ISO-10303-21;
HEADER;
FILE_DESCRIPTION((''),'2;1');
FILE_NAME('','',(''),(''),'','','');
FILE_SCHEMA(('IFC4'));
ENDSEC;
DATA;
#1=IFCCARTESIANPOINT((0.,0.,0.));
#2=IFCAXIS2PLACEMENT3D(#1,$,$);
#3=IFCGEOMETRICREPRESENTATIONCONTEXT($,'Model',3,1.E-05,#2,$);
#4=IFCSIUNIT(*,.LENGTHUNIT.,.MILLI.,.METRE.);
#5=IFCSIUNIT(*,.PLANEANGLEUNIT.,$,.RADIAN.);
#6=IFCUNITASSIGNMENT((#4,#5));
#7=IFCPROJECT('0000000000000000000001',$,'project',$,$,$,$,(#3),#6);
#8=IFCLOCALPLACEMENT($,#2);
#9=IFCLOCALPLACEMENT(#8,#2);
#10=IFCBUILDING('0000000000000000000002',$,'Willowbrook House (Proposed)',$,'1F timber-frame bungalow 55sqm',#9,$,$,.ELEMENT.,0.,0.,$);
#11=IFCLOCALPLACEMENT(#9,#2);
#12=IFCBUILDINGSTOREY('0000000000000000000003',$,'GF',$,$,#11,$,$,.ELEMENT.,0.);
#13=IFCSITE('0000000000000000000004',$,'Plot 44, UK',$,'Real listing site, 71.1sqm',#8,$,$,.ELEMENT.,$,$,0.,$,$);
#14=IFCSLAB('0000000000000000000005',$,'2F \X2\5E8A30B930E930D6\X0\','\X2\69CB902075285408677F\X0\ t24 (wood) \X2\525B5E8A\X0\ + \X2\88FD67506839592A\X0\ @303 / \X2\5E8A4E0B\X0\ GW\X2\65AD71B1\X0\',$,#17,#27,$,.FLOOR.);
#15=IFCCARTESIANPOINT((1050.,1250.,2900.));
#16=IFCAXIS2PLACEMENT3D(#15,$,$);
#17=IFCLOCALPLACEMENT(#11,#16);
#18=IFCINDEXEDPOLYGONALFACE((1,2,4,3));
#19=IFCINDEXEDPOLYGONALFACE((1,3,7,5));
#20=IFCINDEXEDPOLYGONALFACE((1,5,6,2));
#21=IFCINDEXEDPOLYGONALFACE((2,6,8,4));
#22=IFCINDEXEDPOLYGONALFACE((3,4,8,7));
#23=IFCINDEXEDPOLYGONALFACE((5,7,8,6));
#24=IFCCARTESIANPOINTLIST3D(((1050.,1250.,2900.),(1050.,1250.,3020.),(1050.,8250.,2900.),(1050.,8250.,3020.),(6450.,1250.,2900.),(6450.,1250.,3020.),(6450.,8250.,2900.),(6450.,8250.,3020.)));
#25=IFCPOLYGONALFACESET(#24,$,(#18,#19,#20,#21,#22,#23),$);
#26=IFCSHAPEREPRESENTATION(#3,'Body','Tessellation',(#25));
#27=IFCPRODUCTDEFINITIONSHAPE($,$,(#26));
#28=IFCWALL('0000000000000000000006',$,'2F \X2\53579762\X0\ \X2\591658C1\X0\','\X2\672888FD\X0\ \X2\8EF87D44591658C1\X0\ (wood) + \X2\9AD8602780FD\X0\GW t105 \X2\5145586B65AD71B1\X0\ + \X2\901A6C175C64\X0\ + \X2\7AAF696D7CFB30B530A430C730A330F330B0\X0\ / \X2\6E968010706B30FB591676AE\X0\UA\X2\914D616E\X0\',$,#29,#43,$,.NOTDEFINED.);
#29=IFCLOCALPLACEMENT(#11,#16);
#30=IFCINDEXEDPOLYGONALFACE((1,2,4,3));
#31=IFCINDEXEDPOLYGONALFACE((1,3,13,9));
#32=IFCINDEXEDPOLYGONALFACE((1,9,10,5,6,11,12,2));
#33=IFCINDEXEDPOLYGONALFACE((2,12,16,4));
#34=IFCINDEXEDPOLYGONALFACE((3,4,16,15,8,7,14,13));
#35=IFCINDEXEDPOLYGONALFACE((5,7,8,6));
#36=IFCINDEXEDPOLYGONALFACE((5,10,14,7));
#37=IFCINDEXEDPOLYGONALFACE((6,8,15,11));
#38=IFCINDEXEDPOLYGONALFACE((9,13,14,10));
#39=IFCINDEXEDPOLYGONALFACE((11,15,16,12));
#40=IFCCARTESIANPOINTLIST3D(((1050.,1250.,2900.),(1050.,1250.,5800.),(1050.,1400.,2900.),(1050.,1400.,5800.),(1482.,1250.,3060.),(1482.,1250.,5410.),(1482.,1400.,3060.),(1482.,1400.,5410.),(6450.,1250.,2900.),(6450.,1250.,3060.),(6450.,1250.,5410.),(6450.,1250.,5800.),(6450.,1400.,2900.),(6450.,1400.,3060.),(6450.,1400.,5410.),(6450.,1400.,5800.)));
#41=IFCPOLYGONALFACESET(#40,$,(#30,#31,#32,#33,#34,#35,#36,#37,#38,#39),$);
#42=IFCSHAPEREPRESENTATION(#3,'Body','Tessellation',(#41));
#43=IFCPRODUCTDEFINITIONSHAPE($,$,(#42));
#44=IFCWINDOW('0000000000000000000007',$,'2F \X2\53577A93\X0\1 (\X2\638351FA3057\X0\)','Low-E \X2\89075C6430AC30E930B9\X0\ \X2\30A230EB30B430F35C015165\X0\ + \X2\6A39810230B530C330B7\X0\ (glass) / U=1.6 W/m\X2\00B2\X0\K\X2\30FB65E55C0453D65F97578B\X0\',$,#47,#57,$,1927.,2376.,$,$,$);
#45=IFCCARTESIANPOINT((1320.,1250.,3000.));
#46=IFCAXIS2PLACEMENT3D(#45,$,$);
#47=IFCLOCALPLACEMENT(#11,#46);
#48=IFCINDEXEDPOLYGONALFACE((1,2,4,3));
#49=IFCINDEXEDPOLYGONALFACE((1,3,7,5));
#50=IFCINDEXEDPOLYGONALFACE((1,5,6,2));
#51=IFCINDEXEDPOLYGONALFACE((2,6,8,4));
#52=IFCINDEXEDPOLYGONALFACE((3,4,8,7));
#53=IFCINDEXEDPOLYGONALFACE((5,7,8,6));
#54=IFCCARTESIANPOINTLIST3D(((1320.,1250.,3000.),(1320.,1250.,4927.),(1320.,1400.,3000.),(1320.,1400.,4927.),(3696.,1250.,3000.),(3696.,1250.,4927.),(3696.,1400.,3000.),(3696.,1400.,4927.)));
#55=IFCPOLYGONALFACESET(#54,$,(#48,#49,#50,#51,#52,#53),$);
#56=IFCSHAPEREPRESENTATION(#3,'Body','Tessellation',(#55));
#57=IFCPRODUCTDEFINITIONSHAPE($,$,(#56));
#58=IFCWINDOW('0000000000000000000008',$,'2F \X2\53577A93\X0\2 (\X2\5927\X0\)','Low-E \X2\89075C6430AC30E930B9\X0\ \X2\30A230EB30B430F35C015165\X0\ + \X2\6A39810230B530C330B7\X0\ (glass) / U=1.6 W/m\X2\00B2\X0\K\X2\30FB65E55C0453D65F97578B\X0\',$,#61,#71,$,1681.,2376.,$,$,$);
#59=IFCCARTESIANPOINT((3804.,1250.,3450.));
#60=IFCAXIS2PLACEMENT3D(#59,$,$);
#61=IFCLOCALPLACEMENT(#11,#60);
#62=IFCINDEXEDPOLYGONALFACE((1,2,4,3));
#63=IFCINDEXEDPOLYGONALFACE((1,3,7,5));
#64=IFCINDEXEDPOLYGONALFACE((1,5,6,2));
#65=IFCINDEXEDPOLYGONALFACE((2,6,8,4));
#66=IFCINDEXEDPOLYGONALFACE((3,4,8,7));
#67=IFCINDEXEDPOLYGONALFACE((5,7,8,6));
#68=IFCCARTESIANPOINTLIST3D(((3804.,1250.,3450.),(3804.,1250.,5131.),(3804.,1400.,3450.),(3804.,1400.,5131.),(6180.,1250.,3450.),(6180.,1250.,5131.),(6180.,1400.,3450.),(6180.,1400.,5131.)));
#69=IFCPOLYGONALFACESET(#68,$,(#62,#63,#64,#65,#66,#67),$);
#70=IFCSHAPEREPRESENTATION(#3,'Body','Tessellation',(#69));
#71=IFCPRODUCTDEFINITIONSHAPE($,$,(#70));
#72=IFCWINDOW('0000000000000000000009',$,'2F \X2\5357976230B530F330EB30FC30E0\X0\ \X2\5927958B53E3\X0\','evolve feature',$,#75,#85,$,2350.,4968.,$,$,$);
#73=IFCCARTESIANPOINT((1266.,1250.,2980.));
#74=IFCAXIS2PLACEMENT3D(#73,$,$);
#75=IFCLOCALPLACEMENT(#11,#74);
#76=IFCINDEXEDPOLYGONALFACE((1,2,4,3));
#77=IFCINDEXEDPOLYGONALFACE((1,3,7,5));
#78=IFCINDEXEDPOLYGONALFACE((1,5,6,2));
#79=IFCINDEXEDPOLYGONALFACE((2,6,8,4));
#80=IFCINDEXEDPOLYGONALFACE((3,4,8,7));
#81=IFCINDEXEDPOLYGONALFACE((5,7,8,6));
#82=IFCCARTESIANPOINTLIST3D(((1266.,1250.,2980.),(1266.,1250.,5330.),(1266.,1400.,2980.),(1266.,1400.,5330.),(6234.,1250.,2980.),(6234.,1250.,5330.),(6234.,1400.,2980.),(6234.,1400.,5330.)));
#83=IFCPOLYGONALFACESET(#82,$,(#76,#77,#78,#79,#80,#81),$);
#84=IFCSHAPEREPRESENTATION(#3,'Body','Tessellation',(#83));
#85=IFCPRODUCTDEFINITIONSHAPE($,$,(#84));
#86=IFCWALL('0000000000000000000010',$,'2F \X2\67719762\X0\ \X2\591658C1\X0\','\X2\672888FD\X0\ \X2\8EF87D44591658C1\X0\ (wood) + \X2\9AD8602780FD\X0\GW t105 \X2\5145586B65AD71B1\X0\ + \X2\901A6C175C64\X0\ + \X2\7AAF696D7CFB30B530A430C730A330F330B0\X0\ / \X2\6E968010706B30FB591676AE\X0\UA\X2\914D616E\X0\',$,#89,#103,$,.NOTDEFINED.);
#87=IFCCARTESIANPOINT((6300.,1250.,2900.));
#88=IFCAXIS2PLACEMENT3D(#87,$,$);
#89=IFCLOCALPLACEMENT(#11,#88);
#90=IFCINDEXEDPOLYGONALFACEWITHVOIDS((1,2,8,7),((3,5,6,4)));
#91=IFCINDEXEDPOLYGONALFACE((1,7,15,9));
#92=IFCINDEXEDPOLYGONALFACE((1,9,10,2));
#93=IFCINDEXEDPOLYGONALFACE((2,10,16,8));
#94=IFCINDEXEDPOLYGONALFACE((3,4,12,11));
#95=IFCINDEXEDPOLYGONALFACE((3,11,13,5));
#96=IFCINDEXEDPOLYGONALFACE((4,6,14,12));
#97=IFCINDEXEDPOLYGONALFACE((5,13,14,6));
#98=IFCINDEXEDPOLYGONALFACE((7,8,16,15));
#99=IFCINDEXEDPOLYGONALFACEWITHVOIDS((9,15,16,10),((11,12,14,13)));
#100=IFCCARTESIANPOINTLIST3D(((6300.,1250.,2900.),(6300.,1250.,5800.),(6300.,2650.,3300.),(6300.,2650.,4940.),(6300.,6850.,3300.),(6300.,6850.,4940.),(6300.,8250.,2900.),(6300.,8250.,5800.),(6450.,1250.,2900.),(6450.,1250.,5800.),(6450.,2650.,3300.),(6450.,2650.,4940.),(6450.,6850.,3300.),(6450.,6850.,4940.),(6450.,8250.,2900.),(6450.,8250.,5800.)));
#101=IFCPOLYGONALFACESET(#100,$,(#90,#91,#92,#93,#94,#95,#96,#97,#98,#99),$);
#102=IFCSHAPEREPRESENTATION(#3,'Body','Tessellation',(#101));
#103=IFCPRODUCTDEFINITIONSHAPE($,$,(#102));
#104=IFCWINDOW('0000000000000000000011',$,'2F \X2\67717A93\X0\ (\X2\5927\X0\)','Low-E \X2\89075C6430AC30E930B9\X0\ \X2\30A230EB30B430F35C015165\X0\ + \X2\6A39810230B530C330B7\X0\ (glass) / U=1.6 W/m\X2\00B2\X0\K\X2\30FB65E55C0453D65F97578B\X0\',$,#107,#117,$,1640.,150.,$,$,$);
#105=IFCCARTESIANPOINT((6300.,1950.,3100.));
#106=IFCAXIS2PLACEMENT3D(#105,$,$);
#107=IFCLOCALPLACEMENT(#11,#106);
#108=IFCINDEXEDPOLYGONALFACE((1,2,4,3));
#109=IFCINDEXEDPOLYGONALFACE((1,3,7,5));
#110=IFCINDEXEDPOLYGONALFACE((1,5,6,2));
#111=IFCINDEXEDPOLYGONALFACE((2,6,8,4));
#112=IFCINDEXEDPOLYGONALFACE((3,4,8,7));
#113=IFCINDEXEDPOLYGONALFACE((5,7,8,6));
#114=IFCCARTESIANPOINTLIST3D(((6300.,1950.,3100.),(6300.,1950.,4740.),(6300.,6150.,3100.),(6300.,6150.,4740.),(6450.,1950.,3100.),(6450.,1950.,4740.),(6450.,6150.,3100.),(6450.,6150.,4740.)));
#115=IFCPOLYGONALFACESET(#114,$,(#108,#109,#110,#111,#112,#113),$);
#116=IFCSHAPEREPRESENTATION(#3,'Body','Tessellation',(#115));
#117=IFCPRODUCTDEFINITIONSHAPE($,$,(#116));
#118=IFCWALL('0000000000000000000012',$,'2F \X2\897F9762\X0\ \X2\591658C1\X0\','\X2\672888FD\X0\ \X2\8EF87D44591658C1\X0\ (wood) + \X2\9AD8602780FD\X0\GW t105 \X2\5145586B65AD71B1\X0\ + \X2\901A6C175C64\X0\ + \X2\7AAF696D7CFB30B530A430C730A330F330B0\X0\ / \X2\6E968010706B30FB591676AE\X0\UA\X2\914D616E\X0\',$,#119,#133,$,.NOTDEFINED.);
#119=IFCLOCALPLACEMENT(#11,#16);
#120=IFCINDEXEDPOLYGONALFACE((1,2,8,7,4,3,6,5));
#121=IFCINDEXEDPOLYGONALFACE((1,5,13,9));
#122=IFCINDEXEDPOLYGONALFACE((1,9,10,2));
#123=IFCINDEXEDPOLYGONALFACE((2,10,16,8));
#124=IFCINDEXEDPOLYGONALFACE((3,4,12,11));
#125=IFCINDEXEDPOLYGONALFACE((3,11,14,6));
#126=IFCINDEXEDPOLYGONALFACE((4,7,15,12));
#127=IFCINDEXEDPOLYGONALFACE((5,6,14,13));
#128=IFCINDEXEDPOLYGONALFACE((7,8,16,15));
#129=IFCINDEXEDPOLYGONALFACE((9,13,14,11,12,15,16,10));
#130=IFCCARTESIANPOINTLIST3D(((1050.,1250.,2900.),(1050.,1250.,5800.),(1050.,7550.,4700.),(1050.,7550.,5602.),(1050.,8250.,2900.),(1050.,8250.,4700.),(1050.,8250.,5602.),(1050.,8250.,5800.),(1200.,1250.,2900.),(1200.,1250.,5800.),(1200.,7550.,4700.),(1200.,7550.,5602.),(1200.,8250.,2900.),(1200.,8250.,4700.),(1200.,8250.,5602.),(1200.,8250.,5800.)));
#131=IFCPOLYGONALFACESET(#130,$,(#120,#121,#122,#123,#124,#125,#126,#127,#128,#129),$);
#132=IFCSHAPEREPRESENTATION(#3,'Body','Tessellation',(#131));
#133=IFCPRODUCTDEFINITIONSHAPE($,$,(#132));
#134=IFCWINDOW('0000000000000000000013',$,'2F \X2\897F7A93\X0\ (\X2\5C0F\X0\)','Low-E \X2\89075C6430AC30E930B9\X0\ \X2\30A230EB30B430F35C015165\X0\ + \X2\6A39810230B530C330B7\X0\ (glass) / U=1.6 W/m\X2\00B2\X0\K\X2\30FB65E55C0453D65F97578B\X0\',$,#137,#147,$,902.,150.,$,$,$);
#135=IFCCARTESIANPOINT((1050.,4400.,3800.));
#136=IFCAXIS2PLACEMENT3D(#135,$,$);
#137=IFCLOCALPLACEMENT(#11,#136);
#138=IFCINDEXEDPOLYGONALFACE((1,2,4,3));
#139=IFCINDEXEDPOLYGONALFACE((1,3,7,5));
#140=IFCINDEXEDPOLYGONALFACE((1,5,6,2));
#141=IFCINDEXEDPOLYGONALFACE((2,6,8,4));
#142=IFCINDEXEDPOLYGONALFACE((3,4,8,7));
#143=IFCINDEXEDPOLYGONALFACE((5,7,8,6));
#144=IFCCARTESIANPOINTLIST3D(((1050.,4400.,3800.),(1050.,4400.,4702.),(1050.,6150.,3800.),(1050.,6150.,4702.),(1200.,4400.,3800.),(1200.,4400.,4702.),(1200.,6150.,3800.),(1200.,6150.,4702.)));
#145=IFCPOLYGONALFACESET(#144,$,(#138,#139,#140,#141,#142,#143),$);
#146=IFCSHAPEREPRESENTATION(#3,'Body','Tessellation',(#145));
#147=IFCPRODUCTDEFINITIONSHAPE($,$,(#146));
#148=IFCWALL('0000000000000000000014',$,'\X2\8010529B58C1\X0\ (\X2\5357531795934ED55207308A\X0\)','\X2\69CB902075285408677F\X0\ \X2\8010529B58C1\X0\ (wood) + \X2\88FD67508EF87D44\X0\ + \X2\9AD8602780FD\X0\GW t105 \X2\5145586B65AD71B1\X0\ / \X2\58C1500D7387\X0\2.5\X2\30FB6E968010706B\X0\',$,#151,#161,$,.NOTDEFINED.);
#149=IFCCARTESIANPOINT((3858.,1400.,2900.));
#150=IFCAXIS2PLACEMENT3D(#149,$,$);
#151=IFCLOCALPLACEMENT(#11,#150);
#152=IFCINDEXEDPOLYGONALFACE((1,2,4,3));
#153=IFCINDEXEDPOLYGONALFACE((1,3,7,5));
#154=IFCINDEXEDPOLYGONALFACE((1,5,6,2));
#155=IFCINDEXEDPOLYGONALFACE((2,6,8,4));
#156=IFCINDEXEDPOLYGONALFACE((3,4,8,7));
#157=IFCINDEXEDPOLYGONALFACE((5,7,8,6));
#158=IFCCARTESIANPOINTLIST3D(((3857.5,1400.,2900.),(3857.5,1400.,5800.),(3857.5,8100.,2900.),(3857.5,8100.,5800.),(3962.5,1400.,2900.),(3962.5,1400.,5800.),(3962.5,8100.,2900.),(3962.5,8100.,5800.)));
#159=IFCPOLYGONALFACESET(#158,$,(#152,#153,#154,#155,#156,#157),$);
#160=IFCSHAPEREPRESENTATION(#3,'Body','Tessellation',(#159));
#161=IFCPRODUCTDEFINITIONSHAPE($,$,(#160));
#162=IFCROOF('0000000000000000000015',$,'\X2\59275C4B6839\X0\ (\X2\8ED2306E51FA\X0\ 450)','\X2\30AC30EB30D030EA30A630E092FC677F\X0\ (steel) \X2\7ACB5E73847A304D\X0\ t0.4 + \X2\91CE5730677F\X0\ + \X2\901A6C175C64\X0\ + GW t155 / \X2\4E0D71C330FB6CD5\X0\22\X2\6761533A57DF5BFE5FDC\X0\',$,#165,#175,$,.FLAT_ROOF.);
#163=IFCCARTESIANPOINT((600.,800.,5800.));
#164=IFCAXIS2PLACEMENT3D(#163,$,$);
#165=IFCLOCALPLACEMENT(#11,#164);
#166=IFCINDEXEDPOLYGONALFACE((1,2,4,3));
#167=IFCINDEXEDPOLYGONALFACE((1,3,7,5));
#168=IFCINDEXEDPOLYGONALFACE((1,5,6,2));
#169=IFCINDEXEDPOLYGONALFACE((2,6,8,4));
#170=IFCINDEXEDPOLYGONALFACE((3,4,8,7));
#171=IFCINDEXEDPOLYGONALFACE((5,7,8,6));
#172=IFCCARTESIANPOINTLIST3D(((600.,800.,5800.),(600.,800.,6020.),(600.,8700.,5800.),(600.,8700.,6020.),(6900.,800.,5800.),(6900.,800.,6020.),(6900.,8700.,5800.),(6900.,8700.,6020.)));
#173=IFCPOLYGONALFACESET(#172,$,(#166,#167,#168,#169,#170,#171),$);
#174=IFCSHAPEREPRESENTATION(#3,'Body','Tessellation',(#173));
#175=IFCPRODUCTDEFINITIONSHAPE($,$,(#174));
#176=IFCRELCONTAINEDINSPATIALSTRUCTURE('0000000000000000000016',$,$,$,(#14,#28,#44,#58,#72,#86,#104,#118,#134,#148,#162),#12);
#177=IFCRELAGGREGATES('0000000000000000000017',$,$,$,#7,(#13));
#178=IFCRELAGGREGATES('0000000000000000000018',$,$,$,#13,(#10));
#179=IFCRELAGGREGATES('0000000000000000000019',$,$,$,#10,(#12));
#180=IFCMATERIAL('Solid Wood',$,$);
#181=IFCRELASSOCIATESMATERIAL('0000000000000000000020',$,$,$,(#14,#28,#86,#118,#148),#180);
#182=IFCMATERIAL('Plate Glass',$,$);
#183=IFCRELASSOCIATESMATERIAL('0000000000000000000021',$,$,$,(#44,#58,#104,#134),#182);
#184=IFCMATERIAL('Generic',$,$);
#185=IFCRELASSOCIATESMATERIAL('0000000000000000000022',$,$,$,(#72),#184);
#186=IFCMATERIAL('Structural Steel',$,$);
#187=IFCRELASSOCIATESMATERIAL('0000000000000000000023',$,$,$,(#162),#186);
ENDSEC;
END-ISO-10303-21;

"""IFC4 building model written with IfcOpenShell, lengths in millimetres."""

from ifc_helpers import new_model, si_unit, frame, frame_2d, origin, place, context, project, spatial, rectangle, extrude, material, element, fill, save


model = new_model("IFC4")

# Units and contexts
model_context = context("Model", 3, precision=1e-05, world=origin())
ifc_project = project(units=[si_unit("LENGTHUNIT", "METRE", prefix="MILLI"), si_unit("PLANEANGLEUNIT", "RADIAN")], contexts=[model_context])

# Site, building, storey
site_placement = place(None, origin())
site = spatial("IfcSite", under=ifc_project, at=site_placement, Name="Plot 44, UK", ObjectType="Real listing site, 71.1sqm", CompositionType="ELEMENT", RefElevation=0.0)
building_placement = place(site_placement, origin())
building = spatial("IfcBuilding", under=site, at=building_placement, Name="Willowbrook House (Proposed)", ObjectType="1F timber-frame bungalow 55sqm", CompositionType="ELEMENT", ElevationOfRefHeight=0.0, ElevationOfTerrain=0.0)
storey_placement = place(building_placement, origin())
storey = spatial("IfcBuildingStorey", under=building, at=storey_placement, Name="GF", CompositionType="ELEMENT", Elevation=0.0)

# Slab
ifc_material_1 = material(Name="Solid Wood")
slab_placement = place(storey_placement, frame((1050.0, 1250.0, 2900.0)))
element("IfcSlab", 1, at=slab_placement, inside=storey, material=ifc_material_1, Name="2F 床スラブ", Description="構造用合板 t24 (wood) 剛床 + 製材根太 @303 / 床下 GW断熱", PredefinedType="FLOOR", context=model_context, shape_type="SweptSolid", body=[
    extrude(rectangle(XDim=5400.0, YDim=7000.0, at=frame_2d((2700.0, 3500.0))), frame((1050.0, 1250.0, 2900.0)), (0.0, 0.0, 1.0), 120.0),
])

# Wall, openings, windows
wall_1_placement = place(storey_placement, frame((1050.0, 1250.0, 2900.0)))
wall_1 = element("IfcWall", 2, at=wall_1_placement, inside=storey, material=ifc_material_1, Name="2F 南面 外壁", Description="木製 軸組外壁 (wood) + 高性能GW t105 充填断熱 + 通気層 + 窯業系サイディング / 準耐火・外皮UA配慮", PredefinedType="NOTDEFINED", context=model_context, shape_type="SweptSolid", body=[
    extrude(rectangle(XDim=5400.0, YDim=150.0, at=frame_2d((2700.0, 75.0))), frame((1050.0, 1250.0, 2900.0)), (0.0, 0.0, 1.0), 2900.0),
])
opening_1_placement = place(storey_placement, frame((1320.0, 1250.0, 3000.0)))
opening_1 = element("IfcOpeningElement", 3, at=opening_1_placement, cuts=wall_1, PredefinedType="NOTDEFINED", context=model_context, shape_type="SweptSolid", body=[
    extrude(rectangle(XDim=2376.0, YDim=150.0, at=frame_2d((1188.0, 75.0))), frame((1320.0, 1250.0, 3000.0)), (0.0, 0.0, 1.0), 1927.0),
])
opening_2_placement = place(storey_placement, frame((3804.0, 1250.0, 3450.0)))
opening_2 = element("IfcOpeningElement", 4, at=opening_2_placement, cuts=wall_1, PredefinedType="NOTDEFINED", context=model_context, shape_type="SweptSolid", body=[
    extrude(rectangle(XDim=2376.0, YDim=150.0, at=frame_2d((1188.0, 75.0))), frame((3804.0, 1250.0, 3450.0)), (0.0, 0.0, 1.0), 1681.0),
])
opening_3_placement = place(storey_placement, frame((1266.0, 1250.0, 2980.0)))
opening_3 = element("IfcOpeningElement", 5, at=opening_3_placement, cuts=wall_1, PredefinedType="NOTDEFINED", context=model_context, shape_type="SweptSolid", body=[
    extrude(rectangle(XDim=4968.0, YDim=150.0, at=frame_2d((2484.0, 75.0))), frame((1266.0, 1250.0, 2980.0)), (0.0, 0.0, 1.0), 2350.0),
])
ifc_material_2 = material(Name="Plate Glass")
window_1_placement = place(storey_placement, frame((1320.0, 1250.0, 3000.0)))
window_1 = element("IfcWindow", 6, at=window_1_placement, inside=storey, material=ifc_material_2, Name="2F 南窓1 (掃出し)", Description="Low-E 複層ガラス アルゴン封入 + 樹脂サッシ (glass) / U=1.6 W/m²K・日射取得型", OverallHeight=1927.0, OverallWidth=2376.0, context=model_context, shape_type="SweptSolid", body=[
    extrude(rectangle(XDim=2376.0, YDim=150.0, at=frame_2d((1188.0, 75.0))), frame((1320.0, 1250.0, 3000.0)), (0.0, 0.0, 1.0), 1927.0),
])
fill(opening_1, window_1)
window_2_placement = place(storey_placement, frame((3804.0, 1250.0, 3450.0)))
window_2 = element("IfcWindow", 7, at=window_2_placement, inside=storey, material=ifc_material_2, Name="2F 南窓2 (大)", Description="Low-E 複層ガラス アルゴン封入 + 樹脂サッシ (glass) / U=1.6 W/m²K・日射取得型", OverallHeight=1681.0, OverallWidth=2376.0, context=model_context, shape_type="SweptSolid", body=[
    extrude(rectangle(XDim=2376.0, YDim=150.0, at=frame_2d((1188.0, 75.0))), frame((3804.0, 1250.0, 3450.0)), (0.0, 0.0, 1.0), 1681.0),
])
fill(opening_2, window_2)
ifc_material_3 = material(Name="Generic")
window_3_placement = place(storey_placement, frame((1266.0, 1250.0, 2980.0)))
window_3 = element("IfcWindow", 8, at=window_3_placement, inside=storey, material=ifc_material_3, Name="2F 南面サンルーム 大開口", Description="evolve feature", OverallHeight=2350.0, OverallWidth=4968.0, context=model_context, shape_type="SweptSolid", body=[
    extrude(rectangle(XDim=4968.0, YDim=150.0, at=frame_2d((2484.0, 75.0))), frame((1266.0, 1250.0, 2980.0)), (0.0, 0.0, 1.0), 2350.0),
])
fill(opening_3, window_3)

# Walls, openings, windows
wall_2_placement = place(storey_placement, frame((6300.0, 1250.0, 2900.0)))
wall_2 = element("IfcWall", 9, at=wall_2_placement, inside=storey, material=ifc_material_1, Name="2F 東面 外壁", Description="木製 軸組外壁 (wood) + 高性能GW t105 充填断熱 + 通気層 + 窯業系サイディング / 準耐火・外皮UA配慮", PredefinedType="NOTDEFINED", context=model_context, shape_type="SweptSolid", body=[
    extrude(rectangle(XDim=150.0, YDim=7000.0, at=frame_2d((75.0, 3500.0))), frame((6300.0, 1250.0, 2900.0)), (0.0, 0.0, 1.0), 2900.0),
])
opening_4_placement = place(storey_placement, frame((6300.0, 1950.0, 3100.0)))
opening_4 = element("IfcOpeningElement", 10, at=opening_4_placement, cuts=wall_2, PredefinedType="NOTDEFINED", context=model_context, shape_type="SweptSolid", body=[
    extrude(rectangle(XDim=150.0, YDim=4200.0, at=frame_2d((75.0, 2100.0))), frame((6300.0, 1950.0, 3100.0)), (0.0, 0.0, 1.0), 1640.0),
])
window_4_placement = place(storey_placement, frame((6300.0, 1950.0, 3100.0)))
window_4 = element("IfcWindow", 11, at=window_4_placement, inside=storey, material=ifc_material_2, Name="2F 東窓 (大)", Description="Low-E 複層ガラス アルゴン封入 + 樹脂サッシ (glass) / U=1.6 W/m²K・日射取得型", OverallHeight=1640.0, OverallWidth=150.0, context=model_context, shape_type="SweptSolid", body=[
    extrude(rectangle(XDim=150.0, YDim=4200.0, at=frame_2d((75.0, 2100.0))), frame((6300.0, 1950.0, 3100.0)), (0.0, 0.0, 1.0), 1640.0),
])
fill(opening_4, window_4)
wall_3_placement = place(storey_placement, frame((1050.0, 1250.0, 2900.0)))
wall_3 = element("IfcWall", 12, at=wall_3_placement, inside=storey, material=ifc_material_1, Name="2F 西面 外壁", Description="木製 軸組外壁 (wood) + 高性能GW t105 充填断熱 + 通気層 + 窯業系サイディング / 準耐火・外皮UA配慮", PredefinedType="NOTDEFINED", context=model_context, shape_type="SweptSolid", body=[
    extrude(rectangle(XDim=150.0, YDim=7000.0, at=frame_2d((75.0, 3500.0))), frame((1050.0, 1250.0, 2900.0)), (0.0, 0.0, 1.0), 2900.0),
])
opening_5_placement = place(storey_placement, frame((1050.0, 4400.0, 3800.0)))
opening_5 = element("IfcOpeningElement", 13, at=opening_5_placement, cuts=wall_3, PredefinedType="NOTDEFINED", context=model_context, shape_type="SweptSolid", body=[
    extrude(rectangle(XDim=150.0, YDim=1750.0, at=frame_2d((75.0, 875.0))), frame((1050.0, 4400.0, 3800.0)), (0.0, 0.0, 1.0), 902.0),
])
window_5_placement = place(storey_placement, frame((1050.0, 4400.0, 3800.0)))
window_5 = element("IfcWindow", 14, at=window_5_placement, inside=storey, material=ifc_material_2, Name="2F 西窓 (小)", Description="Low-E 複層ガラス アルゴン封入 + 樹脂サッシ (glass) / U=1.6 W/m²K・日射取得型", OverallHeight=902.0, OverallWidth=150.0, context=model_context, shape_type="SweptSolid", body=[
    extrude(rectangle(XDim=150.0, YDim=1750.0, at=frame_2d((75.0, 875.0))), frame((1050.0, 4400.0, 3800.0)), (0.0, 0.0, 1.0), 902.0),
])
fill(opening_5, window_5)

# Wall
wall_4_placement = place(storey_placement, frame((3858.0, 1400.0, 2900.0)))
element("IfcWall", 15, at=wall_4_placement, inside=storey, material=ifc_material_1, Name="耐力壁 (南北間仕切り)", Description="構造用合板 耐力壁 (wood) + 製材軸組 + 高性能GW t105 充填断熱 / 壁倍率2.5・準耐火", PredefinedType="NOTDEFINED", context=model_context, shape_type="SweptSolid", body=[
    extrude(rectangle(XDim=105.0, YDim=6700.0, at=frame_2d((52.0, 3350.0))), frame((3858.0, 1400.0, 2900.0)), (0.0, 0.0, 1.0), 2900.0),
])

# Roof
ifc_material_4 = material(Name="Structural Steel")
roof_placement = place(storey_placement, frame((600.0, 800.0, 5800.0)))
element("IfcRoof", 16, at=roof_placement, inside=storey, material=ifc_material_4, Name="大屋根 (軒の出 450)", Description="ガルバリウム鋼板 (steel) 立平葺き t0.4 + 野地板 + 通気層 + GW t155 / 不燃・法22条区域対応", PredefinedType="FLAT_ROOF", context=model_context, shape_type="SweptSolid", body=[
    extrude(rectangle(XDim=6300.0, YDim=7900.0, at=frame_2d((3150.0, 3950.0))), frame((600.0, 800.0, 5800.0)), (0.0, 0.0, 1.0), 220.0),
])

save(model, "model.ifc")
